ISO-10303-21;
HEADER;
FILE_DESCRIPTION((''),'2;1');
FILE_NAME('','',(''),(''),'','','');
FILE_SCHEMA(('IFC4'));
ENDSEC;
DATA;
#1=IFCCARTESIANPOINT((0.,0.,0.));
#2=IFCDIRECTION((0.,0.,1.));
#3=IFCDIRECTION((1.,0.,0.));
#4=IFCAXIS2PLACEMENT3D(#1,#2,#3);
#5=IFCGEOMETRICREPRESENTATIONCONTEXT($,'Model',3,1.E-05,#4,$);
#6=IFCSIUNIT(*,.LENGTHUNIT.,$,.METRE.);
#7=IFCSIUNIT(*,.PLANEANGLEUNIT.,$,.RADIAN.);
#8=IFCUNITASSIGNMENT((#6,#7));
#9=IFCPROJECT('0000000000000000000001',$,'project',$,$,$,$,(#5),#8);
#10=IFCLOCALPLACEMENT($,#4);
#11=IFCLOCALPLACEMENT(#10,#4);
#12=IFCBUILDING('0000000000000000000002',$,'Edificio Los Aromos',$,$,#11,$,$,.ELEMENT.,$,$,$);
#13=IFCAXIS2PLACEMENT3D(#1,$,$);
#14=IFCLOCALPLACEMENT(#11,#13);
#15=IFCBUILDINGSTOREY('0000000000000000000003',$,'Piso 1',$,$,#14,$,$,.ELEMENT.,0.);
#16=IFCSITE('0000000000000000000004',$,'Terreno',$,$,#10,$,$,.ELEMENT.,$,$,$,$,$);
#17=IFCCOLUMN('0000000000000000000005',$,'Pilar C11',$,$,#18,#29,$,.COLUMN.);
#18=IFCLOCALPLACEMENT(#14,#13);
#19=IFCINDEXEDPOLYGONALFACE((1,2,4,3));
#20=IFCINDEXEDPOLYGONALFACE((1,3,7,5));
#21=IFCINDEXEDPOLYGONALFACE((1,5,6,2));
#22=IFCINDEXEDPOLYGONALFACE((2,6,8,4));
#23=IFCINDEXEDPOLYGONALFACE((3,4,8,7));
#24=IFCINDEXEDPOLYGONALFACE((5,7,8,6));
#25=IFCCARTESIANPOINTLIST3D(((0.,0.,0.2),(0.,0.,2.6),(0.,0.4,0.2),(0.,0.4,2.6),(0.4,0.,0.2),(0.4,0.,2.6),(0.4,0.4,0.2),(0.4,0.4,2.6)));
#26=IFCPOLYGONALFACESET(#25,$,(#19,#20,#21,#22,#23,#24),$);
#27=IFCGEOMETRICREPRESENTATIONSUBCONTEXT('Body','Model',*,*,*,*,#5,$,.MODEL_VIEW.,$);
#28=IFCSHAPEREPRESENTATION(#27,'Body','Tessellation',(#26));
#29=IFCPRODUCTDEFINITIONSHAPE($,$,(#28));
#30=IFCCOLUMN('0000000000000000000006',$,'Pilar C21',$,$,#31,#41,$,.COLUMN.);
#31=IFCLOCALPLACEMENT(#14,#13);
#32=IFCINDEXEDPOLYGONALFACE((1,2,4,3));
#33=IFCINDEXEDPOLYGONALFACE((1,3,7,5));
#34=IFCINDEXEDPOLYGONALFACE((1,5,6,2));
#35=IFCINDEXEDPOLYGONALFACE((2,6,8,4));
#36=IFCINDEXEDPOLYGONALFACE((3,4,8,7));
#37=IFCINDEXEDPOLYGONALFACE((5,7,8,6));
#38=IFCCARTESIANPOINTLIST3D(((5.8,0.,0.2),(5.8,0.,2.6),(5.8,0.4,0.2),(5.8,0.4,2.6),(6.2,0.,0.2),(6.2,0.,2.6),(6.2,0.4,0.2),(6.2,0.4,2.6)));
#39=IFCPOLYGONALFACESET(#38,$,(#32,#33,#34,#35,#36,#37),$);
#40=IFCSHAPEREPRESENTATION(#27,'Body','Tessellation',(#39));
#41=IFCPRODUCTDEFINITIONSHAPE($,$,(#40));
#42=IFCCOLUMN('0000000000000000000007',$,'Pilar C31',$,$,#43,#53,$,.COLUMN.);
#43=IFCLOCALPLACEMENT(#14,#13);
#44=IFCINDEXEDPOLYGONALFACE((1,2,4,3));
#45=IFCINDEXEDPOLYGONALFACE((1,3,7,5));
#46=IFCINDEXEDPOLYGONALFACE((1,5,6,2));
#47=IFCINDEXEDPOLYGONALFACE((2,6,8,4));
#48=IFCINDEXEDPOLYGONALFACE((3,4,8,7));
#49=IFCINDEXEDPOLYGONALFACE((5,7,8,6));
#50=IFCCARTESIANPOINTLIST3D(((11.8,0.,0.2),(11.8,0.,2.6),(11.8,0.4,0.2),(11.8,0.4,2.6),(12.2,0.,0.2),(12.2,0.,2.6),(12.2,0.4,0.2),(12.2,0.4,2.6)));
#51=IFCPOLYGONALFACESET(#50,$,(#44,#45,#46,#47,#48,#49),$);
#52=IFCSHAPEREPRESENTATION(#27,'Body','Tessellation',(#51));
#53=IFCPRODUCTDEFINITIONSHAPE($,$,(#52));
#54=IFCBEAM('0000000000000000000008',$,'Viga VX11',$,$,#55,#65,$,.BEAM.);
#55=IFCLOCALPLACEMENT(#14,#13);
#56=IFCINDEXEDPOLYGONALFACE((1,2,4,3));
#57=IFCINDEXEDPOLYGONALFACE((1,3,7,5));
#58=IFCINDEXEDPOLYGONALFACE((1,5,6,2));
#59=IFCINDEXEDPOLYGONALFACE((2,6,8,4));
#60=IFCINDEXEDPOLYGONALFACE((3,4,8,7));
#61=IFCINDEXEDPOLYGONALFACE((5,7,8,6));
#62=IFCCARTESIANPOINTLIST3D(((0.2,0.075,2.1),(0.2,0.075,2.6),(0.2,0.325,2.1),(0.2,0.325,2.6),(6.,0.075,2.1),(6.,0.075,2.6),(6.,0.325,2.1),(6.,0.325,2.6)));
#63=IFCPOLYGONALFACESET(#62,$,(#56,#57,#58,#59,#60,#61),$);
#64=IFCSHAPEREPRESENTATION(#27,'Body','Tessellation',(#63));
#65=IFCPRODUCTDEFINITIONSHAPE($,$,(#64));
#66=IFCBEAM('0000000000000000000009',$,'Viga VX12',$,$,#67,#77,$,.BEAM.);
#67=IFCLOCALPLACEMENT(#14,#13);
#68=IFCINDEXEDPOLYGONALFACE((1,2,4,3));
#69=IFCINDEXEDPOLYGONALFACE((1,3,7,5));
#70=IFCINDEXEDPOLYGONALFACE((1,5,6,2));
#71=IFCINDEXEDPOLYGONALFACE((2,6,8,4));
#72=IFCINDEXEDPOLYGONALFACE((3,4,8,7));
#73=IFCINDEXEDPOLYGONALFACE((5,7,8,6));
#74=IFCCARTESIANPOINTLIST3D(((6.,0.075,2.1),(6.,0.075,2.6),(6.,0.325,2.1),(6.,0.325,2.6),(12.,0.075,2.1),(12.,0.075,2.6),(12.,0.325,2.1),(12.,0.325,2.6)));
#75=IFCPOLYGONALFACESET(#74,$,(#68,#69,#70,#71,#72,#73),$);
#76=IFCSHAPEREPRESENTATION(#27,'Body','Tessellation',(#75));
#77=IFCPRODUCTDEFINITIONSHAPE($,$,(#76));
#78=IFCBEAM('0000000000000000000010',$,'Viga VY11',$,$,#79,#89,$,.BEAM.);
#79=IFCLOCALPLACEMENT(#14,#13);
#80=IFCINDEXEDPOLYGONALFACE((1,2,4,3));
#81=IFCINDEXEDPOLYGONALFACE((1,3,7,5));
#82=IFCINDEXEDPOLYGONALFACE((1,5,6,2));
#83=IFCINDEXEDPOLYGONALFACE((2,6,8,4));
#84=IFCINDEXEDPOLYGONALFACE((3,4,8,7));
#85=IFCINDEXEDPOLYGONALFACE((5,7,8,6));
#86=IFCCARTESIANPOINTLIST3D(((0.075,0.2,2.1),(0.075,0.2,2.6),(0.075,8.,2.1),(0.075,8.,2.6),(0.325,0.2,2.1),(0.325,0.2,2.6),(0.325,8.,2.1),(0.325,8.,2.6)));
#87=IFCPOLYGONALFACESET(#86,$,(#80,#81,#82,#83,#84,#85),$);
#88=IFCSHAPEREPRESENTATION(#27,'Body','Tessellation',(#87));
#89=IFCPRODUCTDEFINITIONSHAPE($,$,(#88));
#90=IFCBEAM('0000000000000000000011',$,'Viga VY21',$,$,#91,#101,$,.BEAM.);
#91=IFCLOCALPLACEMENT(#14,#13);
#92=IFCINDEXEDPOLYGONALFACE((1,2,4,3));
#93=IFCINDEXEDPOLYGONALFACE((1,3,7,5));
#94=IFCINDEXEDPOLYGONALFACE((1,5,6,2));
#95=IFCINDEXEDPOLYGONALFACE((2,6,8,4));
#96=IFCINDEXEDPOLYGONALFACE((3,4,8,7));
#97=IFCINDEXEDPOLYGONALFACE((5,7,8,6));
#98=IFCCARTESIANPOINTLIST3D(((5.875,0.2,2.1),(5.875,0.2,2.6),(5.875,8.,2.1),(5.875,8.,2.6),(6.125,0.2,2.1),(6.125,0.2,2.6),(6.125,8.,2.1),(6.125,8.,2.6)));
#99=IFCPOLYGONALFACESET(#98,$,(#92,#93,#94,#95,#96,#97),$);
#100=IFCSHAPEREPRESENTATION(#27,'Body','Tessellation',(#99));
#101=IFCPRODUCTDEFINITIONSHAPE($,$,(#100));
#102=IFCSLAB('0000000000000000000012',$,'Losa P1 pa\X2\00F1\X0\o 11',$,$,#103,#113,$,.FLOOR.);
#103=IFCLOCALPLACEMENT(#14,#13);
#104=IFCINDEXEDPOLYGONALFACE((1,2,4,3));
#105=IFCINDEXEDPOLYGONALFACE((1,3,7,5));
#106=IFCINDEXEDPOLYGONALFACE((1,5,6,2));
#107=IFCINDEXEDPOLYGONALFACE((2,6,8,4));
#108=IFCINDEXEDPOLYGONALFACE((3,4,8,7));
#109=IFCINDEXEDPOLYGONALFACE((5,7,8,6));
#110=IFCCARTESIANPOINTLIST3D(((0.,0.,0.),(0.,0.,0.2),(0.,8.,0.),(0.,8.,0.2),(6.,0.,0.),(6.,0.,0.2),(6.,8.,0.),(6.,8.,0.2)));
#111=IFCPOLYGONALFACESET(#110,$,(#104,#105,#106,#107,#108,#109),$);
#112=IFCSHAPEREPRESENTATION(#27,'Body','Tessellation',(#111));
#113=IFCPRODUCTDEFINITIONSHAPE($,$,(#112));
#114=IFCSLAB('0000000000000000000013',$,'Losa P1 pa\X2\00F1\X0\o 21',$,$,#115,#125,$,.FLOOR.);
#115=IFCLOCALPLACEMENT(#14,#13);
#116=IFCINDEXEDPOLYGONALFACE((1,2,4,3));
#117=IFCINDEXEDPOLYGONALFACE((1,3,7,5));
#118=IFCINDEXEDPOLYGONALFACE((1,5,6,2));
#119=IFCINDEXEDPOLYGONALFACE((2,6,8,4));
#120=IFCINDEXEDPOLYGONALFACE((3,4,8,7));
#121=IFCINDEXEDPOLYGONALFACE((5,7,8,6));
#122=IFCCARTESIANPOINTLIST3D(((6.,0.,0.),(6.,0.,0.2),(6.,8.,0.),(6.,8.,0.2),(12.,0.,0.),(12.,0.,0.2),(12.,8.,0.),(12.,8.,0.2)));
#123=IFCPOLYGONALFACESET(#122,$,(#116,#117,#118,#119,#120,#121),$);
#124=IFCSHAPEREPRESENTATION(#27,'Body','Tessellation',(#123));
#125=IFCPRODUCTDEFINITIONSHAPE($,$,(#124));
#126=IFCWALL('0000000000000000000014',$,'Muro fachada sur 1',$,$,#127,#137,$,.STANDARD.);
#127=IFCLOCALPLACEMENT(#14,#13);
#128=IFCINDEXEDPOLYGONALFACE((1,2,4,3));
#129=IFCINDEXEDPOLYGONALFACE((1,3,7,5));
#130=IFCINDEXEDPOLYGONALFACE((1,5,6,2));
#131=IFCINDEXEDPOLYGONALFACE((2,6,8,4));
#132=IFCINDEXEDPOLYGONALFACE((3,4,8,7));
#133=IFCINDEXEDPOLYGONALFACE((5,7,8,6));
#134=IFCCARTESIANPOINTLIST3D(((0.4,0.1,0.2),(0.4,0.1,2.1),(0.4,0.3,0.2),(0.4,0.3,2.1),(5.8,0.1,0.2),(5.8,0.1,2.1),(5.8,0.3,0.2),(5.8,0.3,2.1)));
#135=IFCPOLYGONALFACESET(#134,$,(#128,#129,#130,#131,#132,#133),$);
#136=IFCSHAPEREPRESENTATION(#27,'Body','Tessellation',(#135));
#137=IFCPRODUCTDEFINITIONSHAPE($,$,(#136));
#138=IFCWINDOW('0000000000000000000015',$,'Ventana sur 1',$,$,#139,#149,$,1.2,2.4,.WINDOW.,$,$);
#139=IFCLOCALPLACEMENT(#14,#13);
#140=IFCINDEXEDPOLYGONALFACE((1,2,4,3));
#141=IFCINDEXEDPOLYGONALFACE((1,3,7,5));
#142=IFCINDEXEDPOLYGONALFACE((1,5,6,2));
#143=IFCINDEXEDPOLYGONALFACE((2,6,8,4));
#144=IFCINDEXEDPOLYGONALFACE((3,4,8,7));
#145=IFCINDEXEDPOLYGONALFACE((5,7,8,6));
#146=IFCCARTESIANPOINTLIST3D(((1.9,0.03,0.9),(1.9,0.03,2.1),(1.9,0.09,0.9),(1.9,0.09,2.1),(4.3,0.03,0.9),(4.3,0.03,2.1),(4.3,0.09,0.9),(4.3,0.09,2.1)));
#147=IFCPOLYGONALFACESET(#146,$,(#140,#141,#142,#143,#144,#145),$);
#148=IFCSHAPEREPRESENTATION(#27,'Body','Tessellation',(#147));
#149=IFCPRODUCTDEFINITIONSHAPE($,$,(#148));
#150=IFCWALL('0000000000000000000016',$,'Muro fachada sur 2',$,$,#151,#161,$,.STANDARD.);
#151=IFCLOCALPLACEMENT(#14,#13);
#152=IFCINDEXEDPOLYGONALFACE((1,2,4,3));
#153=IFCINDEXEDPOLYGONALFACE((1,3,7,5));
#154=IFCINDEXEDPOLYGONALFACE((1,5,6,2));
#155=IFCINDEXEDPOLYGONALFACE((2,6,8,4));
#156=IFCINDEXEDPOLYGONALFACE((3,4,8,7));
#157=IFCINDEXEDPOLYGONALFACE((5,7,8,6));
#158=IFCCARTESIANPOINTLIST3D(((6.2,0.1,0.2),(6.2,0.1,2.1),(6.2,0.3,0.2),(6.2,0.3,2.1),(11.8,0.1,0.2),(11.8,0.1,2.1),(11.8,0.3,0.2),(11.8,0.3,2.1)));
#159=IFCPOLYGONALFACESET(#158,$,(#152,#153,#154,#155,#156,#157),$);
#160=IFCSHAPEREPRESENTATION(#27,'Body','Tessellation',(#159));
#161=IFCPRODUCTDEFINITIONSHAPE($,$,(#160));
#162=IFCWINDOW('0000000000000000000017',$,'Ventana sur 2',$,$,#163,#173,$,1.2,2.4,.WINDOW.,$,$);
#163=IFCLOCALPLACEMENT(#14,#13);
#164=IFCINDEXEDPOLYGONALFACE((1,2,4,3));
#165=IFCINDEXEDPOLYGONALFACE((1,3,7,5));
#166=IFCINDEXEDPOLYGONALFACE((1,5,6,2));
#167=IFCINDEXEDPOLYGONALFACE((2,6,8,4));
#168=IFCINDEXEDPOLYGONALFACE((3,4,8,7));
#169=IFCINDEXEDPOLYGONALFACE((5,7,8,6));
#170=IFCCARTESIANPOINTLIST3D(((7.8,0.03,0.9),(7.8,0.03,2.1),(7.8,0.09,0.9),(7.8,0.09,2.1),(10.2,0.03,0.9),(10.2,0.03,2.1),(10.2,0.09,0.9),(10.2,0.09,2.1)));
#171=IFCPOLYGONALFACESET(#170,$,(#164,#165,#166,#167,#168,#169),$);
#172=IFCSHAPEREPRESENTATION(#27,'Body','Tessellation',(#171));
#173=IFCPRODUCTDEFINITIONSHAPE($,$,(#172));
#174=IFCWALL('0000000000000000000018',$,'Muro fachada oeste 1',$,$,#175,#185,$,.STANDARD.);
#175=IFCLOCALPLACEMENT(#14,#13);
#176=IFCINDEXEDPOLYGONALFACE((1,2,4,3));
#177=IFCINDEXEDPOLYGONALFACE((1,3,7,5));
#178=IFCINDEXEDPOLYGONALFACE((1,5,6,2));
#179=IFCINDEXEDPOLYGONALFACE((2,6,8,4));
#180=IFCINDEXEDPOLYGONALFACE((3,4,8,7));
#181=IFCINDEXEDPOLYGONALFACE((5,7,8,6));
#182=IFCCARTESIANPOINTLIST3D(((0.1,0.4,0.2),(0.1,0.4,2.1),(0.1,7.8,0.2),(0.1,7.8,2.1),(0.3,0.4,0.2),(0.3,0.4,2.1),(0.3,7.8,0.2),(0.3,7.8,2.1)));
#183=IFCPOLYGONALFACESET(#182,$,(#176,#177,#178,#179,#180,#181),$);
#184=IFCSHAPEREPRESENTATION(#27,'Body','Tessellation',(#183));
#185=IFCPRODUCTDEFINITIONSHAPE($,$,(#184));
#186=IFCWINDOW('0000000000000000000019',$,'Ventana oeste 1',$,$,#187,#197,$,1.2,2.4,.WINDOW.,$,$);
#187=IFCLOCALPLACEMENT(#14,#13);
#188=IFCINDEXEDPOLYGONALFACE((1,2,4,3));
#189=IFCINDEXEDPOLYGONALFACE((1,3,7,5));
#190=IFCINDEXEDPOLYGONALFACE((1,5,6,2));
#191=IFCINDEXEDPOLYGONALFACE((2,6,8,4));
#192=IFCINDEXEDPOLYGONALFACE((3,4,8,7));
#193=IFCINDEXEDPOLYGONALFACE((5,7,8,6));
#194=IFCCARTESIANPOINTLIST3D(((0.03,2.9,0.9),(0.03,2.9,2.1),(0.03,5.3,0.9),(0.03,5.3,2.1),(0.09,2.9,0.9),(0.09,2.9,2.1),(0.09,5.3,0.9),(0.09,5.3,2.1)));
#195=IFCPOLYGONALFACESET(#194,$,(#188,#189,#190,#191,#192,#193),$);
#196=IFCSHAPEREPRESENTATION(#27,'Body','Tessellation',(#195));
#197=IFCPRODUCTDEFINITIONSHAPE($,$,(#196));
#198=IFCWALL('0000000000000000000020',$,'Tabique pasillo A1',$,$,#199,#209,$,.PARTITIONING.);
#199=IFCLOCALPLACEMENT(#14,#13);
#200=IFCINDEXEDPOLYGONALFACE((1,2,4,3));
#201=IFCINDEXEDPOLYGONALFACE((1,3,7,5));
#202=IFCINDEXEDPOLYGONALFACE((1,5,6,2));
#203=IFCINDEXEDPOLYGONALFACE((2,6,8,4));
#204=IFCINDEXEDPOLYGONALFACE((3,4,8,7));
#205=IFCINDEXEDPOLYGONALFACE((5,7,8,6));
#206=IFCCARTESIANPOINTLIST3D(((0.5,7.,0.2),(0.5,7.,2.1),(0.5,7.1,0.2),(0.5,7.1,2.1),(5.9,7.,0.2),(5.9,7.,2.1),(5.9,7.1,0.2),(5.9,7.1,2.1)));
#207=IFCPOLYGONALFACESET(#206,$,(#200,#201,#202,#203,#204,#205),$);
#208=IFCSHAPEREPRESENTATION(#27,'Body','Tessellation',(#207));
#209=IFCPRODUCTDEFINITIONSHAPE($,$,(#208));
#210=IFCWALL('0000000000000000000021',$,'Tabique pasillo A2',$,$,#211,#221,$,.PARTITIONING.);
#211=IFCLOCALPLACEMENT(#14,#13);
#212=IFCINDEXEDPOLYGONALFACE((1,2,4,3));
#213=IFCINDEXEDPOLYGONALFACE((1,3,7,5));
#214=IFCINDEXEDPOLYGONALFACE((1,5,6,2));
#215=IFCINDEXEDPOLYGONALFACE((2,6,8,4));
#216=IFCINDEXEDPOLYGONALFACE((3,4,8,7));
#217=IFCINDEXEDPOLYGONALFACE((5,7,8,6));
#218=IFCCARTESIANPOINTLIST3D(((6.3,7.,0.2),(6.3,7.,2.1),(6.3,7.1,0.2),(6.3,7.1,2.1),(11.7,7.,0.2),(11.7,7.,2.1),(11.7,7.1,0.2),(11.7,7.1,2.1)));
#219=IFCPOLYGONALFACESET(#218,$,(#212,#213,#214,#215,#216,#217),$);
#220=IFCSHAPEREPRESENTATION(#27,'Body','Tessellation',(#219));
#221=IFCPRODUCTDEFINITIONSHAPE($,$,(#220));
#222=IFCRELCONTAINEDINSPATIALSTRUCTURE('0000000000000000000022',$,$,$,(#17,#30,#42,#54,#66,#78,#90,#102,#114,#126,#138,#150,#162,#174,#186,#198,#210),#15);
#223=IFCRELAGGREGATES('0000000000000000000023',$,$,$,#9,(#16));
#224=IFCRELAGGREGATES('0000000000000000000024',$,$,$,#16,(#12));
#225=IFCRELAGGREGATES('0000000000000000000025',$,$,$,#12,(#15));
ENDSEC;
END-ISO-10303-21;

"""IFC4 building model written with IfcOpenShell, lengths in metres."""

from ifc_helpers import new_model, si_unit, frame, frame_2d, origin, origin_with_axes, place, context, subcontext, project, spatial, rectangle, extrude, element, save


model = new_model("IFC4")

# Units and contexts
model_context = context("Model", 3, precision=1e-05, world=origin_with_axes())
body_context = subcontext(model_context, "Body", "Model", "MODEL_VIEW")
ifc_project = project(units=[si_unit("LENGTHUNIT", "METRE"), si_unit("PLANEANGLEUNIT", "RADIAN")], contexts=[model_context])

# Site, building, storey
site_placement = place(None, origin_with_axes())
site = spatial("IfcSite", under=ifc_project, at=site_placement, Name="Terreno", CompositionType="ELEMENT")
building_placement = place(site_placement, origin_with_axes())
building = spatial("IfcBuilding", under=site, at=building_placement, Name="Edificio Los Aromos", CompositionType="ELEMENT")
storey_placement = place(building_placement, origin())
storey = spatial("IfcBuildingStorey", under=building, at=storey_placement, Name="Piso 1", CompositionType="ELEMENT", Elevation=0.0)

# Columns
for number, where, name in (
    (1, (0.0, 0.0, 0.2), "Pilar C11"),
    (2, (5.8, 0.0, 0.2), "Pilar C21"),
    (3, (11.8, 0.0, 0.2), "Pilar C31"),
):
    element("IfcColumn", number, at=place(storey_placement, frame(where)), inside=storey, Name=name, PredefinedType="COLUMN", context=body_context, shape_type="SweptSolid", body=[
        extrude(rectangle(XDim=0.4, YDim=0.4, at=frame_2d((0.2, 0.2))), origin_with_axes(), (0.0, 0.0, 1.0), 2.4),
    ])

# Beams
beam_1_placement = place(storey_placement, frame((0.2, 0.075, 2.1)))
element("IfcBeam", 4, at=beam_1_placement, inside=storey, Name="Viga VX11", PredefinedType="BEAM", context=body_context, shape_type="SweptSolid", body=[
    extrude(rectangle(XDim=5.8, YDim=0.25, at=frame_2d((2.9, 0.125))), origin_with_axes(), (0.0, 0.0, 1.0), 0.5),
])
beam_2_placement = place(storey_placement, frame((6.0, 0.075, 2.1)))
element("IfcBeam", 5, at=beam_2_placement, inside=storey, Name="Viga VX12", PredefinedType="BEAM", context=body_context, shape_type="SweptSolid", body=[
    extrude(rectangle(XDim=6.0, YDim=0.25, at=frame_2d((3.0, 0.125))), origin_with_axes(), (0.0, 0.0, 1.0), 0.5),
])
for number, where, name in (
    (6, (0.075, 0.2, 2.1), "Viga VY11"),
    (7, (5.875, 0.2, 2.1), "Viga VY21"),
):
    element("IfcBeam", number, at=place(storey_placement, frame(where)), inside=storey, Name=name, PredefinedType="BEAM", context=body_context, shape_type="SweptSolid", body=[
        extrude(rectangle(XDim=0.25, YDim=7.8, at=frame_2d((0.125, 3.9))), origin_with_axes(), (0.0, 0.0, 1.0), 0.5),
    ])

# Slabs
for number, where, name in (
    (8, (0.0, 0.0, 0.0), "Losa P1 paño 11"),
    (9, (6.0, 0.0, 0.0), "Losa P1 paño 21"),
):
    element("IfcSlab", number, at=place(storey_placement, frame(where)), inside=storey, Name=name, PredefinedType="FLOOR", context=body_context, shape_type="SweptSolid", body=[
        extrude(rectangle(XDim=6.0, YDim=8.0, at=frame_2d((3.0, 4.0))), origin_with_axes(), (0.0, 0.0, 1.0), 0.2),
    ])

# Wall
wall_1_placement = place(storey_placement, frame((0.4, 0.1, 0.2)))
element("IfcWall", 10, at=wall_1_placement, inside=storey, Name="Muro fachada sur 1", PredefinedType="STANDARD", context=body_context, shape_type="SweptSolid", body=[
    extrude(rectangle(XDim=5.4, YDim=0.2, at=frame_2d((2.7, 0.1))), origin_with_axes(), (0.0, 0.0, 1.0), 1.9),
])

# Window
window_1_placement = place(storey_placement, frame((1.9, 0.03, 0.9)))
element("IfcWindow", 11, at=window_1_placement, inside=storey, Name="Ventana sur 1", OverallHeight=1.2, OverallWidth=2.4, PredefinedType="WINDOW", context=body_context, shape_type="SweptSolid", body=[
    extrude(rectangle(XDim=2.4, YDim=0.06, at=frame_2d((1.2, 0.03))), origin_with_axes(), (0.0, 0.0, 1.0), 1.2),
])

# Wall
wall_2_placement = place(storey_placement, frame((6.2, 0.1, 0.2)))
element("IfcWall", 12, at=wall_2_placement, inside=storey, Name="Muro fachada sur 2", PredefinedType="STANDARD", context=body_context, shape_type="SweptSolid", body=[
    extrude(rectangle(XDim=5.6, YDim=0.2, at=frame_2d((2.8, 0.1))), origin_with_axes(), (0.0, 0.0, 1.0), 1.9),
])

# Window
window_2_placement = place(storey_placement, frame((7.8, 0.03, 0.9)))
element("IfcWindow", 13, at=window_2_placement, inside=storey, Name="Ventana sur 2", OverallHeight=1.2, OverallWidth=2.4, PredefinedType="WINDOW", context=body_context, shape_type="SweptSolid", body=[
    extrude(rectangle(XDim=2.4, YDim=0.06, at=frame_2d((1.2, 0.03))), origin_with_axes(), (0.0, 0.0, 1.0), 1.2),
])

# Wall
wall_3_placement = place(storey_placement, frame((0.1, 0.4, 0.2)))
element("IfcWall", 14, at=wall_3_placement, inside=storey, Name="Muro fachada oeste 1", PredefinedType="STANDARD", context=body_context, shape_type="SweptSolid", body=[
    extrude(rectangle(XDim=0.2, YDim=7.4, at=frame_2d((0.1, 3.7))), origin_with_axes(), (0.0, 0.0, 1.0), 1.9),
])

# Window
window_3_placement = place(storey_placement, frame((0.03, 2.9, 0.9)))
element("IfcWindow", 15, at=window_3_placement, inside=storey, Name="Ventana oeste 1", OverallHeight=1.2, OverallWidth=2.4, PredefinedType="WINDOW", context=body_context, shape_type="SweptSolid", body=[
    extrude(rectangle(XDim=0.06, YDim=2.4, at=frame_2d((0.03, 1.2))), origin_with_axes(), (0.0, 0.0, 1.0), 1.2),
])

# Walls
for number, where, name in (
    (16, (0.5, 7.0, 0.2), "Tabique pasillo A1"),
    (17, (6.3, 7.0, 0.2), "Tabique pasillo A2"),
):
    element("IfcWall", number, at=place(storey_placement, frame(where)), inside=storey, Name=name, PredefinedType="PARTITIONING", context=body_context, shape_type="SweptSolid", body=[
        extrude(rectangle(XDim=5.4, YDim=0.1, at=frame_2d((2.7, 0.05))), origin_with_axes(), (0.0, 0.0, 1.0), 1.9),
    ])

save(model, "model.ifc")
